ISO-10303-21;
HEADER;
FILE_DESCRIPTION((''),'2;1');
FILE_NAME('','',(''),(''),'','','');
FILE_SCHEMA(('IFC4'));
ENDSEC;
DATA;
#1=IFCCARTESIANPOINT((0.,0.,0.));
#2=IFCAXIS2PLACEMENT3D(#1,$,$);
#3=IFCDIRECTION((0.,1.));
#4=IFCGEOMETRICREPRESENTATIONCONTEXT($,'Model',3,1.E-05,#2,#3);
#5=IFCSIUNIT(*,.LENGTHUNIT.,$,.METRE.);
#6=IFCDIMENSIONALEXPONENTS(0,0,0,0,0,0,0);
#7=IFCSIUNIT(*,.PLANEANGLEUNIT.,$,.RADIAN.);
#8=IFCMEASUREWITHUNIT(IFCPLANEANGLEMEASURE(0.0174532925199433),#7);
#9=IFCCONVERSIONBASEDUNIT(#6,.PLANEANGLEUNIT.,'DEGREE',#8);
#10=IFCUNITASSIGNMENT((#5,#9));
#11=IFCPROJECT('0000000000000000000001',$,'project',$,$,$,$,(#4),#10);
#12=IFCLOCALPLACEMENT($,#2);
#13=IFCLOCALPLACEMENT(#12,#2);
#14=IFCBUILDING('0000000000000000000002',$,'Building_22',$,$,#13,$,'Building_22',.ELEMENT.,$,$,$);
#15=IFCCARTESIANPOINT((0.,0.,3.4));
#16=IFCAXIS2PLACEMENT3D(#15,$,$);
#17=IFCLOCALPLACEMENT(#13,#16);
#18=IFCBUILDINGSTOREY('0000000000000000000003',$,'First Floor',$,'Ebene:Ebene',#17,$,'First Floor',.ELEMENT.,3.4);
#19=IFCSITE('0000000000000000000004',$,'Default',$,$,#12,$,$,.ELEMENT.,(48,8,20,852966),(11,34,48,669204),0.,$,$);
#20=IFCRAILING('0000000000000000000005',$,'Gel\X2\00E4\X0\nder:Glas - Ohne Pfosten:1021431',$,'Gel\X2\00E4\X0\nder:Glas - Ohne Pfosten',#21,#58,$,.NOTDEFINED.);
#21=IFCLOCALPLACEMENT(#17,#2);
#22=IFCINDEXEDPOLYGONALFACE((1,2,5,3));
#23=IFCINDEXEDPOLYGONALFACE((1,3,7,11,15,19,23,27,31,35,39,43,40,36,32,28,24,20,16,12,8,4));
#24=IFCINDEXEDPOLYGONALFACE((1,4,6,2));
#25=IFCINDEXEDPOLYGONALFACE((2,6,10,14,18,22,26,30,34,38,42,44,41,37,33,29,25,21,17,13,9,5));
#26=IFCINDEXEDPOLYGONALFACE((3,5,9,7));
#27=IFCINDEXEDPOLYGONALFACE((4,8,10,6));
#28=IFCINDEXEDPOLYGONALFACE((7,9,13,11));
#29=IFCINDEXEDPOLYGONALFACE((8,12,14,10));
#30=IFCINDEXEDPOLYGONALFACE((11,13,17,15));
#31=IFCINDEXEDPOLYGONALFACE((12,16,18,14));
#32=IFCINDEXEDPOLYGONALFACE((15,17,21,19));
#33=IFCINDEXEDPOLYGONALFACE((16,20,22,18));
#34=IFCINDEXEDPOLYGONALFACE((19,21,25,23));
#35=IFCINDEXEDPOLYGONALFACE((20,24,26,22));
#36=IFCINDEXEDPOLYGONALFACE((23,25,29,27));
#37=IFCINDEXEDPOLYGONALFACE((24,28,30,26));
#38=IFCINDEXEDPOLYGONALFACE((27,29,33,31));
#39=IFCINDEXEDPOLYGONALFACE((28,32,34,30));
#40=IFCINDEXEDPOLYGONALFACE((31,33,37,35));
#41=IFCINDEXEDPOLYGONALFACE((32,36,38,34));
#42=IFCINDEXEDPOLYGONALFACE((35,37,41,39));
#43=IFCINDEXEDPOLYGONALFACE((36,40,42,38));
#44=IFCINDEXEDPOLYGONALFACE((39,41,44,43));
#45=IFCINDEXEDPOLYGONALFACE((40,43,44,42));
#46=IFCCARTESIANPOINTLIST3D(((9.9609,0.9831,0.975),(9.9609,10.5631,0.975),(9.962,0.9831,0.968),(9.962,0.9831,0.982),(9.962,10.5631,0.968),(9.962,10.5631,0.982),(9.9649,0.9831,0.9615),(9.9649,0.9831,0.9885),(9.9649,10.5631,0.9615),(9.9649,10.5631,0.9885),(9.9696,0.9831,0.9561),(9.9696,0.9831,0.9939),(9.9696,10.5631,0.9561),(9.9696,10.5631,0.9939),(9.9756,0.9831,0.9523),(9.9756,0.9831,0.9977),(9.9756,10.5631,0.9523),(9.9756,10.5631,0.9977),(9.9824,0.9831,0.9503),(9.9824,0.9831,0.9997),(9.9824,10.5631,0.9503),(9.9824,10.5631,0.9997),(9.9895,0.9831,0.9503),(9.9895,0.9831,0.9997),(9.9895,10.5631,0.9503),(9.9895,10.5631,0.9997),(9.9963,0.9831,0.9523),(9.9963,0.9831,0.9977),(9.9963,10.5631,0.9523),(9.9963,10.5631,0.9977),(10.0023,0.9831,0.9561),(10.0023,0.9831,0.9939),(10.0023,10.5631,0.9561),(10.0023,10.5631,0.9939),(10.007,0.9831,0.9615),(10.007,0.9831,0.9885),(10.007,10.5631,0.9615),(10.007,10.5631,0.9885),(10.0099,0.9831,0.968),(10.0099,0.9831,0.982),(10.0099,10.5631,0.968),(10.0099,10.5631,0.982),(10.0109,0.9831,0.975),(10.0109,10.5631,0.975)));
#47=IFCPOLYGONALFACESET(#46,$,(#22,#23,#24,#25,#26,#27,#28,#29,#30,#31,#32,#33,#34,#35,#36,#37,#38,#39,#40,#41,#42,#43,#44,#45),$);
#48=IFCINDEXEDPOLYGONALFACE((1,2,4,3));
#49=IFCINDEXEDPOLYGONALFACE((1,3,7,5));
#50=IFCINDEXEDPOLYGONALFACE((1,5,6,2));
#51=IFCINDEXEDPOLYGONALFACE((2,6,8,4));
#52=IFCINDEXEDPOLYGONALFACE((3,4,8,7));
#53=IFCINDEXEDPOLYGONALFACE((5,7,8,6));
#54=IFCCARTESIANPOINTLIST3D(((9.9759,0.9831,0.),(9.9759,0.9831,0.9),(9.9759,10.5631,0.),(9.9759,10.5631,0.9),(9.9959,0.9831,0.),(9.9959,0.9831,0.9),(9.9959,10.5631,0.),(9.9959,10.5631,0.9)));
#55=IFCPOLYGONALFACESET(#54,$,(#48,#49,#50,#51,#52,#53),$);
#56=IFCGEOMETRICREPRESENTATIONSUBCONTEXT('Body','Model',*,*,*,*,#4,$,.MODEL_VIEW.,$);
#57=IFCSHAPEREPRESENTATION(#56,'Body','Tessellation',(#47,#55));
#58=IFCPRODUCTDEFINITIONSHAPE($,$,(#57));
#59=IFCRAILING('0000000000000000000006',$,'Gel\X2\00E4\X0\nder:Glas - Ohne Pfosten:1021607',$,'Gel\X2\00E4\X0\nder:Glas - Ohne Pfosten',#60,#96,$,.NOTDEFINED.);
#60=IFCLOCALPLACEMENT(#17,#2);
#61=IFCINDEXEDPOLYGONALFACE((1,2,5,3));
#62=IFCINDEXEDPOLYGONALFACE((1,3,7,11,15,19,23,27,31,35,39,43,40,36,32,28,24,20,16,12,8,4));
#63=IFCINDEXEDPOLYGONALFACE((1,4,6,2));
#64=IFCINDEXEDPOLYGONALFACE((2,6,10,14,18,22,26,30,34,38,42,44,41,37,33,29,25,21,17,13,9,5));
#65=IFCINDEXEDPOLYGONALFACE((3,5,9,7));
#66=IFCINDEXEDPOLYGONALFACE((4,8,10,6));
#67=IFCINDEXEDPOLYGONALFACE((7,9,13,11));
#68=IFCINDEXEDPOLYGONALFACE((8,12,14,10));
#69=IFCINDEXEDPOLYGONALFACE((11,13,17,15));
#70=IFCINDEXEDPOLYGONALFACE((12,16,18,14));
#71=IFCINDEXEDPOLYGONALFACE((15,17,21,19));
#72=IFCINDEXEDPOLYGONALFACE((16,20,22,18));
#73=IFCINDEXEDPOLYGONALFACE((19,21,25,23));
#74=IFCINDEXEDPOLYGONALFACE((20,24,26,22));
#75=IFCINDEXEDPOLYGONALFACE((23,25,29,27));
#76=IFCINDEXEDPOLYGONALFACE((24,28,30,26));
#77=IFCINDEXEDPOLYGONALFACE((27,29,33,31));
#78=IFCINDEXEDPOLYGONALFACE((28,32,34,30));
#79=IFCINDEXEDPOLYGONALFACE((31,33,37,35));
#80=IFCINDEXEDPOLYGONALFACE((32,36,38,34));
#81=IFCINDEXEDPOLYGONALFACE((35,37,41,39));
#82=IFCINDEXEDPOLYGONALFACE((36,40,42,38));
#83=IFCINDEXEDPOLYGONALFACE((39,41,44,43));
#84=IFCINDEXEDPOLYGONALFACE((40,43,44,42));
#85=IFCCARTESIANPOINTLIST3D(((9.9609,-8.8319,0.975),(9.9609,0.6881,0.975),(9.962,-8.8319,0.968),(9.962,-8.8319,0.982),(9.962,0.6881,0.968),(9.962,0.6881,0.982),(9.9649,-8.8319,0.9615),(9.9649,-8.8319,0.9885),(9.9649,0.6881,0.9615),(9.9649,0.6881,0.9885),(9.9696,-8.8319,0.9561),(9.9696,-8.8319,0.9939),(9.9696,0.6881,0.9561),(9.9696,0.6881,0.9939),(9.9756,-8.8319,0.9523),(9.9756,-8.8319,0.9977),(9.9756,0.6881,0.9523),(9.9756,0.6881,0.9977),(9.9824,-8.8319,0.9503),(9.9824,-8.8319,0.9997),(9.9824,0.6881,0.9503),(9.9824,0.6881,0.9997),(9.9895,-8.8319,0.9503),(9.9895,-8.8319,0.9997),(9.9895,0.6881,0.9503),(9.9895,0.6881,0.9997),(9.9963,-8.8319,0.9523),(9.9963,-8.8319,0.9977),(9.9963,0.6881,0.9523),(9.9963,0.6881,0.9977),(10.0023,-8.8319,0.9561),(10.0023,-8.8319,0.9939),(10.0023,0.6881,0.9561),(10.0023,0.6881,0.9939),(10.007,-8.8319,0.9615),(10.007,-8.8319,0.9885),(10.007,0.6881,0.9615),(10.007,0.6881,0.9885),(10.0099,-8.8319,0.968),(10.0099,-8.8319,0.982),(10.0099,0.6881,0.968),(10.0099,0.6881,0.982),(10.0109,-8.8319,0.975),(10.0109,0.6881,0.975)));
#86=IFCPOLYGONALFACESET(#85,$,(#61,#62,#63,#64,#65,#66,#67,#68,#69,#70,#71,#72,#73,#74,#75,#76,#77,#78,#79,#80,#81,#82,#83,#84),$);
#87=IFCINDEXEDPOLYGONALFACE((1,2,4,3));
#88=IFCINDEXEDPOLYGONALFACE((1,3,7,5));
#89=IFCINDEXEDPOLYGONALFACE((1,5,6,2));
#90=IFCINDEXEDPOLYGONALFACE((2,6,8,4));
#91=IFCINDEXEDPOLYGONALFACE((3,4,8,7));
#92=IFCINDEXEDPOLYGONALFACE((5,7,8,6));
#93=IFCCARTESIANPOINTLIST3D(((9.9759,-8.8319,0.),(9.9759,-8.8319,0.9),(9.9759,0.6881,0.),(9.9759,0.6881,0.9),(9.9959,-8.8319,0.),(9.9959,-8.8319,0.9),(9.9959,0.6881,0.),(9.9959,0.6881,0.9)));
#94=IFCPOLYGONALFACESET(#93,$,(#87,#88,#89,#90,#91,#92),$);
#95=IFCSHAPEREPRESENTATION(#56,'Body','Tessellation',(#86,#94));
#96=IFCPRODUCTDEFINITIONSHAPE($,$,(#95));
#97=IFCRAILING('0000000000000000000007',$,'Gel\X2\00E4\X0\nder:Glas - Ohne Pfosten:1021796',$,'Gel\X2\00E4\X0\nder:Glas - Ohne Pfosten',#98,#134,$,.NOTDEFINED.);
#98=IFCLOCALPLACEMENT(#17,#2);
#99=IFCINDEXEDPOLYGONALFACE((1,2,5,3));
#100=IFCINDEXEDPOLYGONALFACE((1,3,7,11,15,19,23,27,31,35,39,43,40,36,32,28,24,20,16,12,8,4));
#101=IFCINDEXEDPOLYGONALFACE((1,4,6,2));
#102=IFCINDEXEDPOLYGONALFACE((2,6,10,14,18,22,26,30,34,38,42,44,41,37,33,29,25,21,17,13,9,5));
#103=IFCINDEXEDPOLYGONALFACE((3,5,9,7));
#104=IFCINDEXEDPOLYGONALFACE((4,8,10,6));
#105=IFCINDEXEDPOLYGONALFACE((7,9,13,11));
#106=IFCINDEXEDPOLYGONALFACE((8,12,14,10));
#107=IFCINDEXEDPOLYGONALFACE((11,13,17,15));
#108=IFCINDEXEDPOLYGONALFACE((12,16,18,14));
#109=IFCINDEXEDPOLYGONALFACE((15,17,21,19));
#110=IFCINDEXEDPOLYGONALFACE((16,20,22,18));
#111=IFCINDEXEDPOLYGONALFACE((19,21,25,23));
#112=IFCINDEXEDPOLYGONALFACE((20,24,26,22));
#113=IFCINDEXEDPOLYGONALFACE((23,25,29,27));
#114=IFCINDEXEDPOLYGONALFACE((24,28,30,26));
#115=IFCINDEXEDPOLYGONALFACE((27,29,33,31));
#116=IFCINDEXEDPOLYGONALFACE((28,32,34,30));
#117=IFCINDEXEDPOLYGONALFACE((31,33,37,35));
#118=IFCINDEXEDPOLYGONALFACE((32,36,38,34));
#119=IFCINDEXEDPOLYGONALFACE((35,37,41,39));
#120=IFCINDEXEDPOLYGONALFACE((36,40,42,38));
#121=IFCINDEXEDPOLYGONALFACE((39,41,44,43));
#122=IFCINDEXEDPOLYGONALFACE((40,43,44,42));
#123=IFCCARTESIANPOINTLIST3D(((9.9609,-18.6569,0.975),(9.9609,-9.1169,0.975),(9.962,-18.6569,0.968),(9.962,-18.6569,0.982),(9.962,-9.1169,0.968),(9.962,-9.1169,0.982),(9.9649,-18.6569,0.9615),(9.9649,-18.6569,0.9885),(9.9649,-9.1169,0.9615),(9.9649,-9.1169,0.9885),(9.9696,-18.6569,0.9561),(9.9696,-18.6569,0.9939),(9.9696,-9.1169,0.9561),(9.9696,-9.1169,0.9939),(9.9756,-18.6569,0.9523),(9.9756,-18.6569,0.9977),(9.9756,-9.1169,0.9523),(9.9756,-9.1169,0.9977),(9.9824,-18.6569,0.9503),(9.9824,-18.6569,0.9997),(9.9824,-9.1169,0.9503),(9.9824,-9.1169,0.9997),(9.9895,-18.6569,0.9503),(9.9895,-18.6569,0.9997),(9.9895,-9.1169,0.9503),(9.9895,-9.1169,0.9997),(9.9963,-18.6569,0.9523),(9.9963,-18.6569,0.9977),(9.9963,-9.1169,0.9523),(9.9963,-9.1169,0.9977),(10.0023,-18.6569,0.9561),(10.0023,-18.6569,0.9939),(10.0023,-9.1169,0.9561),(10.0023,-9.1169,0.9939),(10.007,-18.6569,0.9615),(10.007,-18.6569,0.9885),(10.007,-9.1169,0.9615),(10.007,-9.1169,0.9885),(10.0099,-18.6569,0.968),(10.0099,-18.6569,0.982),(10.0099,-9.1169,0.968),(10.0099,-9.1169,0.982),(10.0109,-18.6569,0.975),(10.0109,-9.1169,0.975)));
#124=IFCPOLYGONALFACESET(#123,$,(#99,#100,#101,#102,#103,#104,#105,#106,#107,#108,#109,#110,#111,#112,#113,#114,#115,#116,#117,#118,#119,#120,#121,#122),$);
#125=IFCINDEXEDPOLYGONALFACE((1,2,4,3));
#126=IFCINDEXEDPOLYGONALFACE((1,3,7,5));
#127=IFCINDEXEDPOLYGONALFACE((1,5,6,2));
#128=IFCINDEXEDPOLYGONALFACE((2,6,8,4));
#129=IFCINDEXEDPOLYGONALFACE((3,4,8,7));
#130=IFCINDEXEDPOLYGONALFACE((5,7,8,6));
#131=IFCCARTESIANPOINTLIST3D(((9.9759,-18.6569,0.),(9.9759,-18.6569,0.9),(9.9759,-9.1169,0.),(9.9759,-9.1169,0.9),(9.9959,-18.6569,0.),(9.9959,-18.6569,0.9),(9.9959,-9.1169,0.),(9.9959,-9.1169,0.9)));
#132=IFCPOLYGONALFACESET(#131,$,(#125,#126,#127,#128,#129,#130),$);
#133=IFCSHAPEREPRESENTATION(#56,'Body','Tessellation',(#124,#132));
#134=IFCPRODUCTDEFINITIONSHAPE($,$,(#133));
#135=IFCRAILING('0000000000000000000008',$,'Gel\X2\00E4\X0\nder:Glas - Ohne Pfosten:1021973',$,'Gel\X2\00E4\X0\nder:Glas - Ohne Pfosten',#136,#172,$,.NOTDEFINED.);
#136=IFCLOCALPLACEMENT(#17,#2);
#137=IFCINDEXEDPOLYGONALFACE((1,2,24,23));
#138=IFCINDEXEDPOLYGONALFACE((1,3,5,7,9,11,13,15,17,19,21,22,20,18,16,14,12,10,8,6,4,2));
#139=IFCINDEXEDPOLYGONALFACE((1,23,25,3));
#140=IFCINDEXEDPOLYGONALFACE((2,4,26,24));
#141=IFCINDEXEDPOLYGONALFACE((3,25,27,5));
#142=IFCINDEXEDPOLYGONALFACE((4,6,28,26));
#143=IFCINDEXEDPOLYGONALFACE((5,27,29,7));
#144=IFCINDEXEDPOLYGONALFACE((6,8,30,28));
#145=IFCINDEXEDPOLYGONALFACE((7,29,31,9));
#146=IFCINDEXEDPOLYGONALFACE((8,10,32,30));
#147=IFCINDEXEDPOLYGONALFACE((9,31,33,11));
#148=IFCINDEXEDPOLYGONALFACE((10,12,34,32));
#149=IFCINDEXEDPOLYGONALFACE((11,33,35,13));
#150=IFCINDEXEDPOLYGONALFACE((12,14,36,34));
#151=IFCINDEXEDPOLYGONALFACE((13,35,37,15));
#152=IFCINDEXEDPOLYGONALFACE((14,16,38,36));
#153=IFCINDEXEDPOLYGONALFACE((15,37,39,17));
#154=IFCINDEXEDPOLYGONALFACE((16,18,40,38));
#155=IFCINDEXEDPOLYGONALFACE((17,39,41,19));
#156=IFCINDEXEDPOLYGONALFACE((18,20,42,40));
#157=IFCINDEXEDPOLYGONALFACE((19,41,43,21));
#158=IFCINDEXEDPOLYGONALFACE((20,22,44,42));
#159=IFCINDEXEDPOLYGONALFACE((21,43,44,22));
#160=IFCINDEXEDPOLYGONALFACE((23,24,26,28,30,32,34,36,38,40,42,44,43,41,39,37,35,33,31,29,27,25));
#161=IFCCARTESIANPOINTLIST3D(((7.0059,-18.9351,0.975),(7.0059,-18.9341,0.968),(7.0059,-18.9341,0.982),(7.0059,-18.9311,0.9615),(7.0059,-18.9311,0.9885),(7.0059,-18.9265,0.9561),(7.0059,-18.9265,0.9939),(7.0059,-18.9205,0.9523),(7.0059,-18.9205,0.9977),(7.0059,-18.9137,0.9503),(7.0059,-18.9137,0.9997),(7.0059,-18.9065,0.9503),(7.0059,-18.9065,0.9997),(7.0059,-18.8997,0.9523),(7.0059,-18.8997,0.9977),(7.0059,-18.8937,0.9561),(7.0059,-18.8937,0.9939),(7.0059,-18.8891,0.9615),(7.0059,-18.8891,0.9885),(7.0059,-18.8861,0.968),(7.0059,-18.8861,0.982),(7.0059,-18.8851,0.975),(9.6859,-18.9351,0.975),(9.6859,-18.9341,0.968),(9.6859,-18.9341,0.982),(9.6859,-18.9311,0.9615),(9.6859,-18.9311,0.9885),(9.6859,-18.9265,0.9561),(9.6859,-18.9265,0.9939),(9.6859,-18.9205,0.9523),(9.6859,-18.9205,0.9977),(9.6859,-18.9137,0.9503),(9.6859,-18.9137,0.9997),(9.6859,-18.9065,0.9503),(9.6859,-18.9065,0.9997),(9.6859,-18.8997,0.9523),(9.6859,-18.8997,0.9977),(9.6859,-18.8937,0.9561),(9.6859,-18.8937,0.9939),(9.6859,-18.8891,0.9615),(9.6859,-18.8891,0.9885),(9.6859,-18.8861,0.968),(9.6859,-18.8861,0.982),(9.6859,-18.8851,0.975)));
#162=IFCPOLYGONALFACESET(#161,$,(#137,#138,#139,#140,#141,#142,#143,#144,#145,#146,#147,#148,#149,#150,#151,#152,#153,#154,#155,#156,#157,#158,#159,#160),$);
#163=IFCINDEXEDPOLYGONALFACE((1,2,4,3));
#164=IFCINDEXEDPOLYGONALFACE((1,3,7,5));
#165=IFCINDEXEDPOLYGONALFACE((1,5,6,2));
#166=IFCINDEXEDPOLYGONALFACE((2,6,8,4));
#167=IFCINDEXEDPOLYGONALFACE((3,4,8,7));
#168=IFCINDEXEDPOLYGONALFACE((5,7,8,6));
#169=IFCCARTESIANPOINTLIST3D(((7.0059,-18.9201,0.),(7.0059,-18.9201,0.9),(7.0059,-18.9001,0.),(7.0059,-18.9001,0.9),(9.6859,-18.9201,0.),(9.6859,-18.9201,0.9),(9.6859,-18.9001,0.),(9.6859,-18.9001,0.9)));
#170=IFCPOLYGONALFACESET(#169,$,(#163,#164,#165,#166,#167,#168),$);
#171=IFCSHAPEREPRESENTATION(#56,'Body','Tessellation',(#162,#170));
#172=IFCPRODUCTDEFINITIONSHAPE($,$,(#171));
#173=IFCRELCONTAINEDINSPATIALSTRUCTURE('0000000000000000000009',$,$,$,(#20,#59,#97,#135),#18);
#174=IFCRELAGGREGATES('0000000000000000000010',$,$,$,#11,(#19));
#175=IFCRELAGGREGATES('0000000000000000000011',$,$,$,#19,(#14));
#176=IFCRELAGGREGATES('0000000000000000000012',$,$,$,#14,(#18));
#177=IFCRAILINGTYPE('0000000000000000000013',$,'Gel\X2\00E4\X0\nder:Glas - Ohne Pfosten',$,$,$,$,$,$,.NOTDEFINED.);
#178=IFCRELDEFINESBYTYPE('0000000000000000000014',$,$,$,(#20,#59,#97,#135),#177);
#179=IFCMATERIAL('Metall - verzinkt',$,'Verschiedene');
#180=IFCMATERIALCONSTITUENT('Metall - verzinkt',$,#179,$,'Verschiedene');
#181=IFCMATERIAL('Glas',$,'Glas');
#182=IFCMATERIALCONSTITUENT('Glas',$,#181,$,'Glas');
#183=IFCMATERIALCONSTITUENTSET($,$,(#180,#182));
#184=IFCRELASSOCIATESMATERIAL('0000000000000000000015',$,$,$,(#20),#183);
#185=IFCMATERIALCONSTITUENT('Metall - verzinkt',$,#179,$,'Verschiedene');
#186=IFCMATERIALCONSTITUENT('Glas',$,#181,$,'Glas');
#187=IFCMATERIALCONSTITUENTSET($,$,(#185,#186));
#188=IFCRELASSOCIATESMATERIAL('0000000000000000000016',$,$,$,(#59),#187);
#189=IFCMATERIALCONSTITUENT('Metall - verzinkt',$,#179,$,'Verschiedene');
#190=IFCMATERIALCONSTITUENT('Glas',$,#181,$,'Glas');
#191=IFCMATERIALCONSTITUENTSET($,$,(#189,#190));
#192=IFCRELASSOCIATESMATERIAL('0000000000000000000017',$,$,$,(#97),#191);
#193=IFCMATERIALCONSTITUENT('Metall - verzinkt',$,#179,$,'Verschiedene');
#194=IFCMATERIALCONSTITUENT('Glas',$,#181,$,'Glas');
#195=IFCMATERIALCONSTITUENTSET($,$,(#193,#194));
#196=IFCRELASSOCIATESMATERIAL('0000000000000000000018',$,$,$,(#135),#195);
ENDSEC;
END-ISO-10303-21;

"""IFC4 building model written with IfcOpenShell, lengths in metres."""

from ifc_helpers import new_model, entity, si_unit, converted_unit, direction, frame, origin, place, context, subcontext, project, spatial, arc, indexed_curve, outline, extrude, material, constituent, constituent_set, type_object, element, save


model = new_model("IFC4")

# Units and contexts
model_context = context("Model", 3, precision=1e-05, world=origin(), true_north=direction((0.0, 1.0)))
body_context = subcontext(model_context, "Body", "Model", "MODEL_VIEW")
ifc_project = project(units=[si_unit("LENGTHUNIT", "METRE"), converted_unit("PLANEANGLEUNIT", "DEGREE", entity("IfcPlaneAngleMeasure", 0.0174532925199433), si_unit("PLANEANGLEUNIT", "RADIAN"), dimensions=[0, 0, 0, 0, 0, 0, 0])], contexts=[model_context])

# Site, building, storey
site_placement = place(None, origin())
site = spatial("IfcSite", under=ifc_project, at=site_placement, Name="Default", CompositionType="ELEMENT", RefLatitude=(48, 8, 20, 852966), RefLongitude=(11, 34, 48, 669204), RefElevation=0.0)
building_placement = place(site_placement, origin())
building = spatial("IfcBuilding", under=site, at=building_placement, Name="Building_22", LongName="Building_22", CompositionType="ELEMENT")
storey_placement = place(building_placement, frame((0.0, 0.0, 3.4)))
storey = spatial("IfcBuildingStorey", under=building, at=storey_placement, Name="First Floor", ObjectType="Ebene:Ebene", LongName="First Floor", CompositionType="ELEMENT", Elevation=3.4)

# Shared definitions
ifc_material_1 = material(Name="Glas", Category="Glas")

# Railings
ifc_material_2 = material(Name="Metall - verzinkt", Category="Verschiedene")
railing_type = type_object("IfcRailingType", Name="Geländer:Glas - Ohne Pfosten", PredefinedType="NOTDEFINED")
ifc_constituent_1 = constituent(ifc_material_2, Name="Metall - verzinkt", Category="Verschiedene")
ifc_constituent_2 = constituent(ifc_material_1, Name="Glas", Category="Glas")
ifc_constituent_set_1 = constituent_set(constituents=[ifc_constituent_1, ifc_constituent_2])
railing_1_placement = place(storey_placement, origin())
element("IfcRailing", 1, at=railing_1_placement, inside=storey, type_object=railing_type, material=ifc_constituent_set_1, Name="Geländer:Glas - Ohne Pfosten:1021431", ObjectType="Geländer:Glas - Ohne Pfosten", PredefinedType="NOTDEFINED", context=body_context, shape_type="SweptSolid", body=[
    extrude(outline(indexed_curve([(-0.025, 0.0), (0.0, -0.025), (0.025, 0.0), (0.0, 0.025)], segments=[arc(1, 2, 3), arc(3, 4, 1)], self_intersect=False)), frame((9.9859, 0.9831, 0.975), z_axis=(0.0, 1.0, 0.0), x_axis=(-1.0, 0.0, 0.0)), (0.0, 0.0, 1.0), 9.58),
    extrude(outline(indexed_curve([(-4.79, -0.01), (4.79, -0.01), (4.79, 0.01), (-4.79, 0.01), (-4.79, -0.01)], self_intersect=False)), frame((9.9859, 5.7731, 0.0), z_axis=(0.0, 0.0, 1.0), x_axis=(0.0, -1.0, 0.0)), (0.0, 0.0, 1.0), 0.9),
])
ifc_constituent_3 = constituent(ifc_material_2, Name="Metall - verzinkt", Category="Verschiedene")
ifc_constituent_4 = constituent(ifc_material_1, Name="Glas", Category="Glas")
ifc_constituent_set_2 = constituent_set(constituents=[ifc_constituent_3, ifc_constituent_4])
railing_2_placement = place(storey_placement, origin())
element("IfcRailing", 2, at=railing_2_placement, inside=storey, type_object=railing_type, material=ifc_constituent_set_2, Name="Geländer:Glas - Ohne Pfosten:1021607", ObjectType="Geländer:Glas - Ohne Pfosten", PredefinedType="NOTDEFINED", context=body_context, shape_type="SweptSolid", body=[
    extrude(outline(indexed_curve([(-0.025, 0.0), (0.0, -0.025), (0.025, 0.0), (0.0, 0.025)], segments=[arc(1, 2, 3), arc(3, 4, 1)], self_intersect=False)), frame((9.9859, -8.8319, 0.975), z_axis=(0.0, 1.0, 0.0), x_axis=(-1.0, 0.0, 0.0)), (0.0, 0.0, 1.0), 9.52),
    extrude(outline(indexed_curve([(-4.76, -0.01), (4.76, -0.01), (4.76, 0.01), (-4.76, 0.01), (-4.76, -0.01)], self_intersect=False)), frame((9.9859, -4.0719, 0.0), z_axis=(0.0, 0.0, 1.0), x_axis=(0.0, -1.0, 0.0)), (0.0, 0.0, 1.0), 0.9),
])
ifc_constituent_5 = constituent(ifc_material_2, Name="Metall - verzinkt", Category="Verschiedene")
ifc_constituent_6 = constituent(ifc_material_1, Name="Glas", Category="Glas")
ifc_constituent_set_3 = constituent_set(constituents=[ifc_constituent_5, ifc_constituent_6])
railing_3_placement = place(storey_placement, origin())
element("IfcRailing", 3, at=railing_3_placement, inside=storey, type_object=railing_type, material=ifc_constituent_set_3, Name="Geländer:Glas - Ohne Pfosten:1021796", ObjectType="Geländer:Glas - Ohne Pfosten", PredefinedType="NOTDEFINED", context=body_context, shape_type="SweptSolid", body=[
    extrude(outline(indexed_curve([(-0.025, 0.0), (0.0, -0.025), (0.025, 0.0), (0.0, 0.025)], segments=[arc(1, 2, 3), arc(3, 4, 1)], self_intersect=False)), frame((9.9859, -18.6569, 0.975), z_axis=(0.0, 1.0, 0.0), x_axis=(-1.0, 0.0, 0.0)), (0.0, 0.0, 1.0), 9.54),
    extrude(outline(indexed_curve([(-4.77, -0.01), (4.77, -0.01), (4.77, 0.01), (-4.77, 0.01), (-4.77, -0.01)], self_intersect=False)), frame((9.9859, -13.8869, 0.0), z_axis=(0.0, 0.0, 1.0), x_axis=(0.0, -1.0, 0.0)), (0.0, 0.0, 1.0), 0.9),
])
ifc_constituent_7 = constituent(ifc_material_2, Name="Metall - verzinkt", Category="Verschiedene")
ifc_constituent_8 = constituent(ifc_material_1, Name="Glas", Category="Glas")
ifc_constituent_set_4 = constituent_set(constituents=[ifc_constituent_7, ifc_constituent_8])
railing_4_placement = place(storey_placement, origin())
element("IfcRailing", 4, at=railing_4_placement, inside=storey, type_object=railing_type, material=ifc_constituent_set_4, Name="Geländer:Glas - Ohne Pfosten:1021973", ObjectType="Geländer:Glas - Ohne Pfosten", PredefinedType="NOTDEFINED", context=body_context, shape_type="SweptSolid", body=[
    extrude(outline(indexed_curve([(-0.025, 0.0), (0.0, -0.025), (0.025, 0.0), (0.0, 0.025)], segments=[arc(1, 2, 3), arc(3, 4, 1)], self_intersect=False)), frame((7.0059, -18.9101, 0.975), z_axis=(1.0, 0.0, 0.0), x_axis=(0.0, 1.0, 0.0)), (0.0, 0.0, 1.0), 2.68),
    extrude(outline(indexed_curve([(-1.34, -0.01), (1.34, -0.01), (1.34, 0.01), (-1.34, 0.01), (-1.34, -0.01)], self_intersect=False)), frame((8.3459, -18.9101, 0.0), z_axis=(0.0, 0.0, 1.0), x_axis=(-1.0, 0.0, 0.0)), (0.0, 0.0, 1.0), 0.9),
])

save(model, "model.ifc")
